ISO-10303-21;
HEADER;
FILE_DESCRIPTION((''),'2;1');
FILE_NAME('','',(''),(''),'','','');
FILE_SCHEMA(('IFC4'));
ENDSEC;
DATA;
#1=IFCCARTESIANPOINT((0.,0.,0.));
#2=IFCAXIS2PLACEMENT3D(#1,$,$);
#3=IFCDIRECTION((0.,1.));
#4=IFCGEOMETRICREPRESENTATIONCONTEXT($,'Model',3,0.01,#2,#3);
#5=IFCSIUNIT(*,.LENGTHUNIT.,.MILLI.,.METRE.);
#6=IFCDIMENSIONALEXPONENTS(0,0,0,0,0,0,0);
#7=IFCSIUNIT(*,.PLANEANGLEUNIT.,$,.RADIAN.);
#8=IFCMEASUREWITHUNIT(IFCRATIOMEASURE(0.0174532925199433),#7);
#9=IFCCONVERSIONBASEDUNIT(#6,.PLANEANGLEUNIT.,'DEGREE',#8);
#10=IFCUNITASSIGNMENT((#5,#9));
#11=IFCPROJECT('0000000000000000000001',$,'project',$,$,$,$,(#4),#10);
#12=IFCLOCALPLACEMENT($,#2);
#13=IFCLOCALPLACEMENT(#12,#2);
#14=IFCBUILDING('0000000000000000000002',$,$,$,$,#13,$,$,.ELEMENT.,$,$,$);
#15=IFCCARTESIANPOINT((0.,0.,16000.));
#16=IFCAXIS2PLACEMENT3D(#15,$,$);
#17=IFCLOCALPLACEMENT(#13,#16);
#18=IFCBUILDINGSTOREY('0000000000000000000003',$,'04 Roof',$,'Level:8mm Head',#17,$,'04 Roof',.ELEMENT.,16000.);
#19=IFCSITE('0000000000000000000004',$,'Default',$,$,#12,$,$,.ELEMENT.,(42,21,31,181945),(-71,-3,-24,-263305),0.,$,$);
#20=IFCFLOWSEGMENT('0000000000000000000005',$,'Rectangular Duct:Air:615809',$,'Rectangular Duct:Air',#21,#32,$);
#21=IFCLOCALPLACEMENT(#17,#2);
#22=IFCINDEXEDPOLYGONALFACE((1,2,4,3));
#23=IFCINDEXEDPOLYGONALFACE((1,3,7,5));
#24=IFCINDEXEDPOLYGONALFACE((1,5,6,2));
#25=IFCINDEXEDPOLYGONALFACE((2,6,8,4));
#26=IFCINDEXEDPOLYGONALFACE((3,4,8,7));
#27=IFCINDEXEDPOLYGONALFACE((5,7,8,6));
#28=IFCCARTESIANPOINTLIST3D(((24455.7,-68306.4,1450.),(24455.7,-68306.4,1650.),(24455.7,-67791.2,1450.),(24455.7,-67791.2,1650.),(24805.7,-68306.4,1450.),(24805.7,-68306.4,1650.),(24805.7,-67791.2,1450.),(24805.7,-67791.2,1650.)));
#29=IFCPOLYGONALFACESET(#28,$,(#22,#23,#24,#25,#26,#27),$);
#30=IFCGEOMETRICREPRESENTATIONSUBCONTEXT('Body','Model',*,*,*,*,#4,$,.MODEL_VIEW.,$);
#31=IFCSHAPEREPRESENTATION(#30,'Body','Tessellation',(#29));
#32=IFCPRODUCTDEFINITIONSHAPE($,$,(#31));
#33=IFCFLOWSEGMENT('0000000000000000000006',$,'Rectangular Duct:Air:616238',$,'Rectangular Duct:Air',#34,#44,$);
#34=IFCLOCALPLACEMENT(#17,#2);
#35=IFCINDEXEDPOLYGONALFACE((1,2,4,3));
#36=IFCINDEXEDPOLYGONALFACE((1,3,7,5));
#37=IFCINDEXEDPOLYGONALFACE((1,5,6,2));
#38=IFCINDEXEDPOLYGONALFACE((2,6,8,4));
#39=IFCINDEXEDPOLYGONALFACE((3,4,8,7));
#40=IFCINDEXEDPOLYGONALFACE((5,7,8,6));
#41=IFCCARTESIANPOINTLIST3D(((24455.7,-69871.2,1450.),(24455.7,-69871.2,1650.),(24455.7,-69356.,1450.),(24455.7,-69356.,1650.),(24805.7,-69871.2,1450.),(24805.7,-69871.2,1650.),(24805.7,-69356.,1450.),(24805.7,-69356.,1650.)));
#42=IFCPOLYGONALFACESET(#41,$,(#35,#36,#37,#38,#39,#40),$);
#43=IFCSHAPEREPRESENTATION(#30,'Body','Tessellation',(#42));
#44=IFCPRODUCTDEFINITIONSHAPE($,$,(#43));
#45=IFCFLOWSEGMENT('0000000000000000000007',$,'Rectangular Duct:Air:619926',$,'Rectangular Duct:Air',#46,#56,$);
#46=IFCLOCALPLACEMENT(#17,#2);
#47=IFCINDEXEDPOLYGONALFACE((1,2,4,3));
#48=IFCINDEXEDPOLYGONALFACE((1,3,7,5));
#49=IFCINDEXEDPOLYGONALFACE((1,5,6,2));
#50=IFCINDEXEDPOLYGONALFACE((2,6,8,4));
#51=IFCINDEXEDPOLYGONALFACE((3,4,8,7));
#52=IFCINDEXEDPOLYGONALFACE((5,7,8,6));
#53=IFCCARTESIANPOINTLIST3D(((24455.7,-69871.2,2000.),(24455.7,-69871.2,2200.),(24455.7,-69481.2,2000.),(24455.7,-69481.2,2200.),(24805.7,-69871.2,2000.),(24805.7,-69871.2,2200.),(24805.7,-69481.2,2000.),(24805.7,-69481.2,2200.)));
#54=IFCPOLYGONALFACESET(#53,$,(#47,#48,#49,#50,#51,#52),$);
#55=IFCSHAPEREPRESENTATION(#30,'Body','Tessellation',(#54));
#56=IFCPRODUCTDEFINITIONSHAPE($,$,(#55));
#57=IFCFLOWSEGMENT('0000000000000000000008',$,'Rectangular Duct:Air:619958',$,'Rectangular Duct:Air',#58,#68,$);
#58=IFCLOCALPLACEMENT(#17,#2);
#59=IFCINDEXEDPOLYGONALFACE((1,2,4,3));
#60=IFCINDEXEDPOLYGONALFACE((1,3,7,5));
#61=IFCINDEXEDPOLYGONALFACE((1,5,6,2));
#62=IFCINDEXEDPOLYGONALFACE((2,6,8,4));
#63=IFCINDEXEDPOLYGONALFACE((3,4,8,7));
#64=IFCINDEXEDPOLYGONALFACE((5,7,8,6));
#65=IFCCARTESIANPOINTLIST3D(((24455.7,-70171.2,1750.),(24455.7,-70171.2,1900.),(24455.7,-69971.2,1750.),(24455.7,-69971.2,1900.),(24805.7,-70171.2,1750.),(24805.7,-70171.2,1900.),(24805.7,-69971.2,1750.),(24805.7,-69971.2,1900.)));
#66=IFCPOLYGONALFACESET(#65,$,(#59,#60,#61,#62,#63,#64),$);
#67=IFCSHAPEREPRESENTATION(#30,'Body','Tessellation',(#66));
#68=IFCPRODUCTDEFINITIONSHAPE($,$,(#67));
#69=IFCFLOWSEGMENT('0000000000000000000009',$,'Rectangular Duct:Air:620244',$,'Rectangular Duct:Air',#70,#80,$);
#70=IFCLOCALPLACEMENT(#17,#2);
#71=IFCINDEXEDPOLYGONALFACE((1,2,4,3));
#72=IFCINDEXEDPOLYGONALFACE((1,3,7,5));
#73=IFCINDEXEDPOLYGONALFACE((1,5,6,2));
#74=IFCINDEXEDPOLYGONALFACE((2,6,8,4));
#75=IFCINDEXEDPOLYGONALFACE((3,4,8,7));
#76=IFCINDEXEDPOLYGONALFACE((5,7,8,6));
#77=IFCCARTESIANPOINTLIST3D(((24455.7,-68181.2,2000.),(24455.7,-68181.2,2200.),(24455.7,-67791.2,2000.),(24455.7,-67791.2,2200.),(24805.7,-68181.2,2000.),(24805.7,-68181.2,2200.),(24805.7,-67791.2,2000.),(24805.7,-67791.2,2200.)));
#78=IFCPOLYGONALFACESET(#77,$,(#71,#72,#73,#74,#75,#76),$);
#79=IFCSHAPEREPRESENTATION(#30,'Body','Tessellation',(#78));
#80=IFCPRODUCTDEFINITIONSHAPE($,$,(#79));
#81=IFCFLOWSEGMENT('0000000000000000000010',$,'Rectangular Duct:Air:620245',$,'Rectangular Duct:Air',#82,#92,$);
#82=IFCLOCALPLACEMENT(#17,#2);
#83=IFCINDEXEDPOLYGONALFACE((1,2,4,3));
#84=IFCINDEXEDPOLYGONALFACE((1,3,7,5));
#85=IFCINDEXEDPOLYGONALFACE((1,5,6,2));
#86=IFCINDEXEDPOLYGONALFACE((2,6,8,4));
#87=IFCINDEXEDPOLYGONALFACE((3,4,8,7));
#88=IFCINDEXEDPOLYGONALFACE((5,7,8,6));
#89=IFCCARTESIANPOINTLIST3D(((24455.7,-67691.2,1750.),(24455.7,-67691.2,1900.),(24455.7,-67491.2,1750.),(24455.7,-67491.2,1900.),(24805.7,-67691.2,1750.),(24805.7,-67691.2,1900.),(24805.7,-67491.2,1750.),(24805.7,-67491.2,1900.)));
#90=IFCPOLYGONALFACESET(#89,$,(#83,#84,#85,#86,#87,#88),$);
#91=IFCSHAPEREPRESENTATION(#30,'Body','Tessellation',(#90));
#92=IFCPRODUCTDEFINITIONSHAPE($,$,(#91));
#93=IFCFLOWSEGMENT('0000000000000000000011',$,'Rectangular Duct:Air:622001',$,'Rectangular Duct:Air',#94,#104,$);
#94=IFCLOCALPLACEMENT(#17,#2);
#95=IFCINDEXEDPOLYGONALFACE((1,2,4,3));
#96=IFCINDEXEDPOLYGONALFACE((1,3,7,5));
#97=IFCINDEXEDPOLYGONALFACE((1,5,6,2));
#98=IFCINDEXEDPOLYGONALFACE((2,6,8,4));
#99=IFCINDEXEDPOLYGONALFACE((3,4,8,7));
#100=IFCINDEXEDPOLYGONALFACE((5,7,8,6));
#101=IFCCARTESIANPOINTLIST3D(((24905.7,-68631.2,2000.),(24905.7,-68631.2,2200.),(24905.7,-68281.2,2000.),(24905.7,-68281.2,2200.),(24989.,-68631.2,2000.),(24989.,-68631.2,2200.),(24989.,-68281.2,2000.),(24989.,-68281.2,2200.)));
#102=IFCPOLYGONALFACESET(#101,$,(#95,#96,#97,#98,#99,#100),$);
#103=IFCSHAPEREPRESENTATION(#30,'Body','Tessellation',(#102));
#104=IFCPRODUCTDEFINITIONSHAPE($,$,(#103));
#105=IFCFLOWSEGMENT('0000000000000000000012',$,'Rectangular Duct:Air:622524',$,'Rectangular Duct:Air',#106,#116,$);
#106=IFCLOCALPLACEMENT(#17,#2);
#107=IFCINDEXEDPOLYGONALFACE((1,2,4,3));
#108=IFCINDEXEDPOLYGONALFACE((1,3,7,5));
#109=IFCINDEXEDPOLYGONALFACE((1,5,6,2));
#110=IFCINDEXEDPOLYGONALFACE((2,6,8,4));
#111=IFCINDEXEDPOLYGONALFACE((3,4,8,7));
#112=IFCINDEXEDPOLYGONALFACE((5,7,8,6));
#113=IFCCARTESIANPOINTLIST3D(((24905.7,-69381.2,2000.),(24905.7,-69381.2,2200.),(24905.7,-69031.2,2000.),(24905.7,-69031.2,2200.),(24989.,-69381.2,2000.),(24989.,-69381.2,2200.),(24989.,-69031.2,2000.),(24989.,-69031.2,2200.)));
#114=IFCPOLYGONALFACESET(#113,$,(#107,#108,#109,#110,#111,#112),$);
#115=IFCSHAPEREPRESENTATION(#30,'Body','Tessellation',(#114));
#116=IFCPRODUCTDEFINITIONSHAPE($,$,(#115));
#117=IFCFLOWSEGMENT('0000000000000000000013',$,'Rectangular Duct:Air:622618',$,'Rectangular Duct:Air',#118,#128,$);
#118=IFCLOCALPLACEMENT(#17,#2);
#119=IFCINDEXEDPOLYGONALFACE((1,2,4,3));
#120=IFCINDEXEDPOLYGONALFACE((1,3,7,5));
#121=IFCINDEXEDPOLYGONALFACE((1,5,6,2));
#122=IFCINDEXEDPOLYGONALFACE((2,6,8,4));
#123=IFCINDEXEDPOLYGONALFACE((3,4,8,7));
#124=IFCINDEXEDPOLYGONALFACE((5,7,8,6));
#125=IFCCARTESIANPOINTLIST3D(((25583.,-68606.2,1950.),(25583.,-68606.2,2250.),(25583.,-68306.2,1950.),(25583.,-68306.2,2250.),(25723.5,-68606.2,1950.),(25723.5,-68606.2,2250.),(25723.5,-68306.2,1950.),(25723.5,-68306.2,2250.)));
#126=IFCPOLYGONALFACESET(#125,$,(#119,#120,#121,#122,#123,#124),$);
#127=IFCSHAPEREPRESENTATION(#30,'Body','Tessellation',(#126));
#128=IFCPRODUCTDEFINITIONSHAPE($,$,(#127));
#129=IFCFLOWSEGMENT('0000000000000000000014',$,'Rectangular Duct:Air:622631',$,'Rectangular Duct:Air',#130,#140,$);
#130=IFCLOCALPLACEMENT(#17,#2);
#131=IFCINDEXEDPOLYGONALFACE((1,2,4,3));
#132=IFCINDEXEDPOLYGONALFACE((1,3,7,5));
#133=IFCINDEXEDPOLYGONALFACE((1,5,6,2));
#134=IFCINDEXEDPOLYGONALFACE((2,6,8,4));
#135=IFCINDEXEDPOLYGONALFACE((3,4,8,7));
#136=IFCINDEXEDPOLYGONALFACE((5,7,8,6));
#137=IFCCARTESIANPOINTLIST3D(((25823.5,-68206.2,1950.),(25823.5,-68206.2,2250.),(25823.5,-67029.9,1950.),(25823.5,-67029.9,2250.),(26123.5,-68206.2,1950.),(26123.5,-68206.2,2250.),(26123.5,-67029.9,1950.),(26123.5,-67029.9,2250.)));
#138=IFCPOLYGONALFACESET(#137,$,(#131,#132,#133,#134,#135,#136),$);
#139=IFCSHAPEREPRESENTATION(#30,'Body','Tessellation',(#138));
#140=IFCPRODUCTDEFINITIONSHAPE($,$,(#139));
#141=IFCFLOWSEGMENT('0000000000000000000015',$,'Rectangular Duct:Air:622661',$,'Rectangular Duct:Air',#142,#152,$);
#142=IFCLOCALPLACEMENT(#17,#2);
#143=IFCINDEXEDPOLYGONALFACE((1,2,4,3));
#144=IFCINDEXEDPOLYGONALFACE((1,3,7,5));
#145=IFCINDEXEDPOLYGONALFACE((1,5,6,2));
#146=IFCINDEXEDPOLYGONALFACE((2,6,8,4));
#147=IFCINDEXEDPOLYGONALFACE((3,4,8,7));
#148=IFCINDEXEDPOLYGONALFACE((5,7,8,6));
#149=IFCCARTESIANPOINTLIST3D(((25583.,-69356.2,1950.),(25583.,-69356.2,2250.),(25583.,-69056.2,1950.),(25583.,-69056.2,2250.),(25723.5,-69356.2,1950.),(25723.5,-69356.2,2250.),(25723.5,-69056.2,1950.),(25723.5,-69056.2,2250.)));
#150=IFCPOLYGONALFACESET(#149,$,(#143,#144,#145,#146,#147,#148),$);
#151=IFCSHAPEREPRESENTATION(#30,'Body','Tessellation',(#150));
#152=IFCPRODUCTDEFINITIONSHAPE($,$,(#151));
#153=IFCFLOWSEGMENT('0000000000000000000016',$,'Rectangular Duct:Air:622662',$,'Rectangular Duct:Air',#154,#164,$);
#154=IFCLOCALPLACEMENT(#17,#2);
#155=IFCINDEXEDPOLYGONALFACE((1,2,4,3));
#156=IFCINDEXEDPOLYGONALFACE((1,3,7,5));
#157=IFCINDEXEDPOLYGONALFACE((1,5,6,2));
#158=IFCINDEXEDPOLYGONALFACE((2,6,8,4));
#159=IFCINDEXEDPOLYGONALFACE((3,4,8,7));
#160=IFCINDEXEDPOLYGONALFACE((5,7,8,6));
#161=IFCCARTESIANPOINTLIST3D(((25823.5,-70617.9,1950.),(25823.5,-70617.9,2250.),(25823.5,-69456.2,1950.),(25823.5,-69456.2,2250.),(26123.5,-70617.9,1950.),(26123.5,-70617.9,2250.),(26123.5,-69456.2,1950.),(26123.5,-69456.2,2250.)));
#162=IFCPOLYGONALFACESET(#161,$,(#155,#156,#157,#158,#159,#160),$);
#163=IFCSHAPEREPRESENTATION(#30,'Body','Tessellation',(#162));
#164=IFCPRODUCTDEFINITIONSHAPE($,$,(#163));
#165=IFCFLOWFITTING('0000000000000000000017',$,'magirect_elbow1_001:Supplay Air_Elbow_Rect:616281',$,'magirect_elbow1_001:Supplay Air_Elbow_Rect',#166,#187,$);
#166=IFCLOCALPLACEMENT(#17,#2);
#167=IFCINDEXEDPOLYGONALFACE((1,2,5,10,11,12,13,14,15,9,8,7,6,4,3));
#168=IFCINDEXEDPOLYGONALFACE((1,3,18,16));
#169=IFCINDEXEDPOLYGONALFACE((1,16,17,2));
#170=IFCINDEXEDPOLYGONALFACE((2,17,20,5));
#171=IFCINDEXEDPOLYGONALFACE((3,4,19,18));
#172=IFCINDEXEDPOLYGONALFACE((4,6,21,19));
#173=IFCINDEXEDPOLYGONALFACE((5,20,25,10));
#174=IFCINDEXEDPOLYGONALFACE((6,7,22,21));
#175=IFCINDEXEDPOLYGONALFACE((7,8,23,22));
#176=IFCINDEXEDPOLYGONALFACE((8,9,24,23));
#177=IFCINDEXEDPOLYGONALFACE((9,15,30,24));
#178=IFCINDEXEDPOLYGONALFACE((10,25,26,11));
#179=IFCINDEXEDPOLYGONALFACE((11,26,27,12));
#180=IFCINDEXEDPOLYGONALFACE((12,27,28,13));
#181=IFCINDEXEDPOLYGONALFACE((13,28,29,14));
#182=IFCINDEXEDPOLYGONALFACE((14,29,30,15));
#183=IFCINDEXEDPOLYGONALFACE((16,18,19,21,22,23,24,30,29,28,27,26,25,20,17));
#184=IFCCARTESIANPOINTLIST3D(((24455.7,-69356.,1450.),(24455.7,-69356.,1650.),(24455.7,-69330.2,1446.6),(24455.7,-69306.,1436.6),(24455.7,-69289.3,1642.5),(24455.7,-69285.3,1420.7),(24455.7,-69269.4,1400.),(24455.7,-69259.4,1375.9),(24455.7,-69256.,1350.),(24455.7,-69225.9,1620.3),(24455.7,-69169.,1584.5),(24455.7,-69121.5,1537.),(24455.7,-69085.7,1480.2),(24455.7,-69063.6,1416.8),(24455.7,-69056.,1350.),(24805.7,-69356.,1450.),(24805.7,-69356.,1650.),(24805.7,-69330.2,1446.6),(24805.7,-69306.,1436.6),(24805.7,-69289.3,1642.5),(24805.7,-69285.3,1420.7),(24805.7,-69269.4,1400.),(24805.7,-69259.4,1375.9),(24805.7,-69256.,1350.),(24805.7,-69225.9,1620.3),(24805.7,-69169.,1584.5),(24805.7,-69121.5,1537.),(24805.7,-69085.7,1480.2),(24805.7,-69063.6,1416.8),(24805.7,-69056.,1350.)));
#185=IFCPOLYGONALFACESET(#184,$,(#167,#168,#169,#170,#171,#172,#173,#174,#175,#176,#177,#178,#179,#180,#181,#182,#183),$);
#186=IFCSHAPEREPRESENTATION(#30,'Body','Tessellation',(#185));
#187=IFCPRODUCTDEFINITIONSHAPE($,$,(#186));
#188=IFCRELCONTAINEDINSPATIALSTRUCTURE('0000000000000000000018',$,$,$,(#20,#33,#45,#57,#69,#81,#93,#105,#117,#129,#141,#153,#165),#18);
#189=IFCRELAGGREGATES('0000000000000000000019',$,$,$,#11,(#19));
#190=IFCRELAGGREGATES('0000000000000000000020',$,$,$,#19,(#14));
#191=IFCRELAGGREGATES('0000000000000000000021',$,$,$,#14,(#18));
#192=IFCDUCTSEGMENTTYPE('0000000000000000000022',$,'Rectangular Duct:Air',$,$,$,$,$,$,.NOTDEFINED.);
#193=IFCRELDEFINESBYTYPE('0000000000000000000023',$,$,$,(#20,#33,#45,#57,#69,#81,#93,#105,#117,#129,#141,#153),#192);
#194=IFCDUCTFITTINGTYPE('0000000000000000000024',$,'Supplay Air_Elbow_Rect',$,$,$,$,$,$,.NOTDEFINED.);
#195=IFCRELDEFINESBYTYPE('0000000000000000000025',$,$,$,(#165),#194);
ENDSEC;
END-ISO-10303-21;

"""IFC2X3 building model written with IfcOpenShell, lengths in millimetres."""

from ifc_helpers import new_model, entity, si_unit, converted_unit, direction, frame, frame_2d, origin, origin_2d_with_axis, place, context, subcontext, project, spatial, polyline, circle_curve, parameter, trimmed, segment, composite_curve, rectangle, outline, extrude, source, transform, mapped, type_object, type_shapes, element, save


model = new_model("IFC2X3")

# Units and contexts
model_context = context("Model", 3, precision=0.01, world=origin(), true_north=direction((0.0, 1.0)))
body_context = subcontext(model_context, "Body", "Model", "MODEL_VIEW")
ifc_project = project(units=[si_unit("LENGTHUNIT", "METRE", prefix="MILLI"), converted_unit("PLANEANGLEUNIT", "DEGREE", entity("IfcRatioMeasure", 0.0174532925199433), si_unit("PLANEANGLEUNIT", "RADIAN"), dimensions=[0, 0, 0, 0, 0, 0, 0])], contexts=[model_context])

# Site, building, storey
site_placement = place(None, origin())
site = spatial("IfcSite", under=ifc_project, at=site_placement, Name="Default", CompositionType="ELEMENT", RefLatitude=(42, 21, 31, 181945), RefLongitude=(-71, -3, -24, -263305), RefElevation=0.0)
building_placement = place(site_placement, origin())
building = spatial("IfcBuilding", under=site, at=building_placement, CompositionType="ELEMENT")
storey_placement = place(building_placement, frame((0.0, 0.0, 16000.0)))
storey = spatial("IfcBuildingStorey", under=building, at=storey_placement, Name="04 Roof", ObjectType="Level:8mm Head", LongName="04 Roof", CompositionType="ELEMENT", Elevation=16000.0)

# Flow segments
duct_segment_type = type_object("IfcDuctSegmentType", Name="Rectangular Duct:Air", PredefinedType="NOTDEFINED")
flow_segment_1_placement = place(storey_placement, frame((24455.7, -68306.4, 1450.0)))
element("IfcFlowSegment", 1, at=flow_segment_1_placement, inside=storey, type_object=duct_segment_type, Name="Rectangular Duct:Air:615809", ObjectType="Rectangular Duct:Air", context=body_context, shape_type="SweptSolid", body=[
    extrude(rectangle(XDim=515.2, YDim=350.0, at=frame_2d((0.0, 0.0), x_axis=(1.0, 0.0))), frame((175.0, 257.6, 0.0), z_axis=(0.0, 0.0, 1.0), x_axis=(0.0, -1.0, 0.0)), (0.0, 0.0, 1.0), 200.0),
])
flow_segment_2_placement = place(storey_placement, frame((24455.7, -69871.2, 1450.0)))
element("IfcFlowSegment", 2, at=flow_segment_2_placement, inside=storey, type_object=duct_segment_type, Name="Rectangular Duct:Air:616238", ObjectType="Rectangular Duct:Air", context=body_context, shape_type="SweptSolid", body=[
    extrude(rectangle(XDim=515.2, YDim=350.0, at=origin_2d_with_axis()), frame((175.0, 257.6, 0.0), z_axis=(0.0, 0.0, 1.0), x_axis=(0.0, -1.0, 0.0)), (0.0, 0.0, 1.0), 200.0),
])
flow_segment_3_placement = place(storey_placement, frame((24455.7, -69871.2, 2000.0)))
element("IfcFlowSegment", 3, at=flow_segment_3_placement, inside=storey, type_object=duct_segment_type, Name="Rectangular Duct:Air:619926", ObjectType="Rectangular Duct:Air", context=body_context, shape_type="SweptSolid", body=[
    extrude(rectangle(XDim=390.0, YDim=350.0, at=origin_2d_with_axis()), frame((175.0, 195.0, 0.0), z_axis=(0.0, 0.0, 1.0), x_axis=(0.0, -1.0, 0.0)), (0.0, 0.0, 1.0), 200.0),
])
flow_segment_4_placement = place(storey_placement, frame((24455.7, -70171.2, 1750.0)))
element("IfcFlowSegment", 4, at=flow_segment_4_placement, inside=storey, type_object=duct_segment_type, Name="Rectangular Duct:Air:619958", ObjectType="Rectangular Duct:Air", context=body_context, shape_type="SweptSolid", body=[
    extrude(rectangle(XDim=200.0, YDim=350.0, at=frame_2d((0.0, 0.0), x_axis=(1.0, 0.0))), frame((175.0, 100.0, 0.0), z_axis=(0.0, 0.0, 1.0), x_axis=(0.0, -1.0, 0.0)), (0.0, 0.0, 1.0), 150.0),
])
flow_segment_5_placement = place(storey_placement, frame((24455.7, -68181.2, 2000.0)))
element("IfcFlowSegment", 5, at=flow_segment_5_placement, inside=storey, type_object=duct_segment_type, Name="Rectangular Duct:Air:620244", ObjectType="Rectangular Duct:Air", context=body_context, shape_type="SweptSolid", body=[
    extrude(rectangle(XDim=390.0, YDim=350.0, at=origin_2d_with_axis()), frame((175.0, 195.0, 0.0), z_axis=(0.0, 0.0, 1.0), x_axis=(0.0, -1.0, 0.0)), (0.0, 0.0, 1.0), 200.0),
])
flow_segment_6_placement = place(storey_placement, frame((24455.7, -67691.2, 1750.0)))
element("IfcFlowSegment", 6, at=flow_segment_6_placement, inside=storey, type_object=duct_segment_type, Name="Rectangular Duct:Air:620245", ObjectType="Rectangular Duct:Air", context=body_context, shape_type="SweptSolid", body=[
    extrude(rectangle(XDim=200.0, YDim=350.0, at=frame_2d((0.0, 0.0), x_axis=(1.0, 0.0))), frame((175.0, 100.0, 0.0), z_axis=(0.0, 0.0, 1.0), x_axis=(0.0, 1.0, 0.0)), (0.0, 0.0, 1.0), 150.0),
])
for number, where, name in (
    (7, (24905.7, -68631.2, 2000.0), "Rectangular Duct:Air:622001"),
    (8, (24905.7, -69381.2, 2000.0), "Rectangular Duct:Air:622524"),
):
    element("IfcFlowSegment", number, at=place(storey_placement, frame(where)), inside=storey, type_object=duct_segment_type, Name=name, ObjectType="Rectangular Duct:Air", context=body_context, shape_type="SweptSolid", body=[
        extrude(rectangle(XDim=83.3, YDim=350.0, at=frame_2d((0.0, 0.0), x_axis=(1.0, 0.0))), frame((41.7, 175.0, 0.0)), (0.0, 0.0, 1.0), 200.0),
    ])
flow_segment_7_placement = place(storey_placement, frame((25583.0, -68606.2, 1950.0)))
element("IfcFlowSegment", 9, at=flow_segment_7_placement, inside=storey, type_object=duct_segment_type, Name="Rectangular Duct:Air:622618", ObjectType="Rectangular Duct:Air", context=body_context, shape_type="SweptSolid", body=[
    extrude(rectangle(XDim=140.5, YDim=300.0, at=frame_2d((0.0, 0.0), x_axis=(1.0, 0.0))), frame((70.3, 150.0, 0.0)), (0.0, 0.0, 1.0), 300.0),
])
flow_segment_8_placement = place(storey_placement, frame((25823.5, -68206.2, 1950.0)))
element("IfcFlowSegment", 10, at=flow_segment_8_placement, inside=storey, type_object=duct_segment_type, Name="Rectangular Duct:Air:622631", ObjectType="Rectangular Duct:Air", context=body_context, shape_type="SweptSolid", body=[
    extrude(rectangle(XDim=1176.3, YDim=300.0, at=origin_2d_with_axis()), frame((150.0, 588.2, 0.0), z_axis=(0.0, 0.0, 1.0), x_axis=(0.0, 1.0, 0.0)), (0.0, 0.0, 1.0), 300.0),
])
flow_segment_9_placement = place(storey_placement, frame((25583.0, -69356.2, 1950.0)))
element("IfcFlowSegment", 11, at=flow_segment_9_placement, inside=storey, type_object=duct_segment_type, Name="Rectangular Duct:Air:622661", ObjectType="Rectangular Duct:Air", context=body_context, shape_type="SweptSolid", body=[
    extrude(rectangle(XDim=140.5, YDim=300.0, at=origin_2d_with_axis()), frame((70.3, 150.0, 0.0), z_axis=(0.0, 0.0, 1.0), x_axis=(-1.0, 0.0, 0.0)), (0.0, 0.0, 1.0), 300.0),
])
flow_segment_10_placement = place(storey_placement, frame((25823.5, -70617.9, 1950.0)))
element("IfcFlowSegment", 12, at=flow_segment_10_placement, inside=storey, type_object=duct_segment_type, Name="Rectangular Duct:Air:622662", ObjectType="Rectangular Duct:Air", context=body_context, shape_type="SweptSolid", body=[
    extrude(rectangle(XDim=1161.7, YDim=300.0, at=frame_2d((0.0, 0.0), x_axis=(1.0, 0.0))), frame((150.0, 580.9, 0.0), z_axis=(0.0, 0.0, 1.0), x_axis=(0.0, -1.0, 0.0)), (0.0, 0.0, 1.0), 300.0),
])

# Flow fitting
duct_fitting_type_1 = type_object("IfcDuctFittingType", Name="Supplay Air_Elbow_Rect", PredefinedType="NOTDEFINED")
shared_shape_1 = source(origin(), body_context, "Body", "SweptSolid", [
    extrude(outline(composite_curve([segment(polyline([(-200.0, -100.0), (0.0, -100.0)]), True, "CONTINUOUS"), segment(trimmed(circle_curve(frame_2d((100.0, -100.0), x_axis=(0.0, 1.0)), 100.0), [parameter(0.0)], [parameter(90.0)], True, "PARAMETER"), False, "CONTINUOUS"), segment(polyline([(100.0, 0.0), (100.0, 200.0)]), True, "CONTINUOUS"), segment(trimmed(circle_curve(frame_2d((100.0, -100.0), x_axis=(0.0, 1.0)), 300.0), [parameter(0.0)], [parameter(90.0)], True, "PARAMETER"), True, "CONTINUOUS")], self_intersect=False)), frame((-100.0, 100.0, -175.0), z_axis=(0.0, 0.0, 1.0), x_axis=(-1.0, 0.0, 0.0)), (0.0, 0.0, 1.0), 350.0),
])
type_shapes(duct_fitting_type_1, [shared_shape_1])
for number, where, z_axis, x_axis, name in (
    (13, (24630.7, -69156.0, 1550.0), (-1.0, 0.0, 0.0), (0.0, 1.0, 0.0), "magirect_elbow1_001:Supplay Air_Elbow_Rect:616281"),
):
    element("IfcFlowFitting", number, at=place(storey_placement, frame(where, z_axis=z_axis, x_axis=x_axis)), inside=storey, type_object=duct_fitting_type_1, Name=name, ObjectType="magirect_elbow1_001:Supplay Air_Elbow_Rect", context=body_context, shape_type="MappedRepresentation", body=[
        mapped(shared_shape_1, transform((0.0, 0.0, 0.0), scale=1.0)),
    ])

save(model, "model.ifc")
